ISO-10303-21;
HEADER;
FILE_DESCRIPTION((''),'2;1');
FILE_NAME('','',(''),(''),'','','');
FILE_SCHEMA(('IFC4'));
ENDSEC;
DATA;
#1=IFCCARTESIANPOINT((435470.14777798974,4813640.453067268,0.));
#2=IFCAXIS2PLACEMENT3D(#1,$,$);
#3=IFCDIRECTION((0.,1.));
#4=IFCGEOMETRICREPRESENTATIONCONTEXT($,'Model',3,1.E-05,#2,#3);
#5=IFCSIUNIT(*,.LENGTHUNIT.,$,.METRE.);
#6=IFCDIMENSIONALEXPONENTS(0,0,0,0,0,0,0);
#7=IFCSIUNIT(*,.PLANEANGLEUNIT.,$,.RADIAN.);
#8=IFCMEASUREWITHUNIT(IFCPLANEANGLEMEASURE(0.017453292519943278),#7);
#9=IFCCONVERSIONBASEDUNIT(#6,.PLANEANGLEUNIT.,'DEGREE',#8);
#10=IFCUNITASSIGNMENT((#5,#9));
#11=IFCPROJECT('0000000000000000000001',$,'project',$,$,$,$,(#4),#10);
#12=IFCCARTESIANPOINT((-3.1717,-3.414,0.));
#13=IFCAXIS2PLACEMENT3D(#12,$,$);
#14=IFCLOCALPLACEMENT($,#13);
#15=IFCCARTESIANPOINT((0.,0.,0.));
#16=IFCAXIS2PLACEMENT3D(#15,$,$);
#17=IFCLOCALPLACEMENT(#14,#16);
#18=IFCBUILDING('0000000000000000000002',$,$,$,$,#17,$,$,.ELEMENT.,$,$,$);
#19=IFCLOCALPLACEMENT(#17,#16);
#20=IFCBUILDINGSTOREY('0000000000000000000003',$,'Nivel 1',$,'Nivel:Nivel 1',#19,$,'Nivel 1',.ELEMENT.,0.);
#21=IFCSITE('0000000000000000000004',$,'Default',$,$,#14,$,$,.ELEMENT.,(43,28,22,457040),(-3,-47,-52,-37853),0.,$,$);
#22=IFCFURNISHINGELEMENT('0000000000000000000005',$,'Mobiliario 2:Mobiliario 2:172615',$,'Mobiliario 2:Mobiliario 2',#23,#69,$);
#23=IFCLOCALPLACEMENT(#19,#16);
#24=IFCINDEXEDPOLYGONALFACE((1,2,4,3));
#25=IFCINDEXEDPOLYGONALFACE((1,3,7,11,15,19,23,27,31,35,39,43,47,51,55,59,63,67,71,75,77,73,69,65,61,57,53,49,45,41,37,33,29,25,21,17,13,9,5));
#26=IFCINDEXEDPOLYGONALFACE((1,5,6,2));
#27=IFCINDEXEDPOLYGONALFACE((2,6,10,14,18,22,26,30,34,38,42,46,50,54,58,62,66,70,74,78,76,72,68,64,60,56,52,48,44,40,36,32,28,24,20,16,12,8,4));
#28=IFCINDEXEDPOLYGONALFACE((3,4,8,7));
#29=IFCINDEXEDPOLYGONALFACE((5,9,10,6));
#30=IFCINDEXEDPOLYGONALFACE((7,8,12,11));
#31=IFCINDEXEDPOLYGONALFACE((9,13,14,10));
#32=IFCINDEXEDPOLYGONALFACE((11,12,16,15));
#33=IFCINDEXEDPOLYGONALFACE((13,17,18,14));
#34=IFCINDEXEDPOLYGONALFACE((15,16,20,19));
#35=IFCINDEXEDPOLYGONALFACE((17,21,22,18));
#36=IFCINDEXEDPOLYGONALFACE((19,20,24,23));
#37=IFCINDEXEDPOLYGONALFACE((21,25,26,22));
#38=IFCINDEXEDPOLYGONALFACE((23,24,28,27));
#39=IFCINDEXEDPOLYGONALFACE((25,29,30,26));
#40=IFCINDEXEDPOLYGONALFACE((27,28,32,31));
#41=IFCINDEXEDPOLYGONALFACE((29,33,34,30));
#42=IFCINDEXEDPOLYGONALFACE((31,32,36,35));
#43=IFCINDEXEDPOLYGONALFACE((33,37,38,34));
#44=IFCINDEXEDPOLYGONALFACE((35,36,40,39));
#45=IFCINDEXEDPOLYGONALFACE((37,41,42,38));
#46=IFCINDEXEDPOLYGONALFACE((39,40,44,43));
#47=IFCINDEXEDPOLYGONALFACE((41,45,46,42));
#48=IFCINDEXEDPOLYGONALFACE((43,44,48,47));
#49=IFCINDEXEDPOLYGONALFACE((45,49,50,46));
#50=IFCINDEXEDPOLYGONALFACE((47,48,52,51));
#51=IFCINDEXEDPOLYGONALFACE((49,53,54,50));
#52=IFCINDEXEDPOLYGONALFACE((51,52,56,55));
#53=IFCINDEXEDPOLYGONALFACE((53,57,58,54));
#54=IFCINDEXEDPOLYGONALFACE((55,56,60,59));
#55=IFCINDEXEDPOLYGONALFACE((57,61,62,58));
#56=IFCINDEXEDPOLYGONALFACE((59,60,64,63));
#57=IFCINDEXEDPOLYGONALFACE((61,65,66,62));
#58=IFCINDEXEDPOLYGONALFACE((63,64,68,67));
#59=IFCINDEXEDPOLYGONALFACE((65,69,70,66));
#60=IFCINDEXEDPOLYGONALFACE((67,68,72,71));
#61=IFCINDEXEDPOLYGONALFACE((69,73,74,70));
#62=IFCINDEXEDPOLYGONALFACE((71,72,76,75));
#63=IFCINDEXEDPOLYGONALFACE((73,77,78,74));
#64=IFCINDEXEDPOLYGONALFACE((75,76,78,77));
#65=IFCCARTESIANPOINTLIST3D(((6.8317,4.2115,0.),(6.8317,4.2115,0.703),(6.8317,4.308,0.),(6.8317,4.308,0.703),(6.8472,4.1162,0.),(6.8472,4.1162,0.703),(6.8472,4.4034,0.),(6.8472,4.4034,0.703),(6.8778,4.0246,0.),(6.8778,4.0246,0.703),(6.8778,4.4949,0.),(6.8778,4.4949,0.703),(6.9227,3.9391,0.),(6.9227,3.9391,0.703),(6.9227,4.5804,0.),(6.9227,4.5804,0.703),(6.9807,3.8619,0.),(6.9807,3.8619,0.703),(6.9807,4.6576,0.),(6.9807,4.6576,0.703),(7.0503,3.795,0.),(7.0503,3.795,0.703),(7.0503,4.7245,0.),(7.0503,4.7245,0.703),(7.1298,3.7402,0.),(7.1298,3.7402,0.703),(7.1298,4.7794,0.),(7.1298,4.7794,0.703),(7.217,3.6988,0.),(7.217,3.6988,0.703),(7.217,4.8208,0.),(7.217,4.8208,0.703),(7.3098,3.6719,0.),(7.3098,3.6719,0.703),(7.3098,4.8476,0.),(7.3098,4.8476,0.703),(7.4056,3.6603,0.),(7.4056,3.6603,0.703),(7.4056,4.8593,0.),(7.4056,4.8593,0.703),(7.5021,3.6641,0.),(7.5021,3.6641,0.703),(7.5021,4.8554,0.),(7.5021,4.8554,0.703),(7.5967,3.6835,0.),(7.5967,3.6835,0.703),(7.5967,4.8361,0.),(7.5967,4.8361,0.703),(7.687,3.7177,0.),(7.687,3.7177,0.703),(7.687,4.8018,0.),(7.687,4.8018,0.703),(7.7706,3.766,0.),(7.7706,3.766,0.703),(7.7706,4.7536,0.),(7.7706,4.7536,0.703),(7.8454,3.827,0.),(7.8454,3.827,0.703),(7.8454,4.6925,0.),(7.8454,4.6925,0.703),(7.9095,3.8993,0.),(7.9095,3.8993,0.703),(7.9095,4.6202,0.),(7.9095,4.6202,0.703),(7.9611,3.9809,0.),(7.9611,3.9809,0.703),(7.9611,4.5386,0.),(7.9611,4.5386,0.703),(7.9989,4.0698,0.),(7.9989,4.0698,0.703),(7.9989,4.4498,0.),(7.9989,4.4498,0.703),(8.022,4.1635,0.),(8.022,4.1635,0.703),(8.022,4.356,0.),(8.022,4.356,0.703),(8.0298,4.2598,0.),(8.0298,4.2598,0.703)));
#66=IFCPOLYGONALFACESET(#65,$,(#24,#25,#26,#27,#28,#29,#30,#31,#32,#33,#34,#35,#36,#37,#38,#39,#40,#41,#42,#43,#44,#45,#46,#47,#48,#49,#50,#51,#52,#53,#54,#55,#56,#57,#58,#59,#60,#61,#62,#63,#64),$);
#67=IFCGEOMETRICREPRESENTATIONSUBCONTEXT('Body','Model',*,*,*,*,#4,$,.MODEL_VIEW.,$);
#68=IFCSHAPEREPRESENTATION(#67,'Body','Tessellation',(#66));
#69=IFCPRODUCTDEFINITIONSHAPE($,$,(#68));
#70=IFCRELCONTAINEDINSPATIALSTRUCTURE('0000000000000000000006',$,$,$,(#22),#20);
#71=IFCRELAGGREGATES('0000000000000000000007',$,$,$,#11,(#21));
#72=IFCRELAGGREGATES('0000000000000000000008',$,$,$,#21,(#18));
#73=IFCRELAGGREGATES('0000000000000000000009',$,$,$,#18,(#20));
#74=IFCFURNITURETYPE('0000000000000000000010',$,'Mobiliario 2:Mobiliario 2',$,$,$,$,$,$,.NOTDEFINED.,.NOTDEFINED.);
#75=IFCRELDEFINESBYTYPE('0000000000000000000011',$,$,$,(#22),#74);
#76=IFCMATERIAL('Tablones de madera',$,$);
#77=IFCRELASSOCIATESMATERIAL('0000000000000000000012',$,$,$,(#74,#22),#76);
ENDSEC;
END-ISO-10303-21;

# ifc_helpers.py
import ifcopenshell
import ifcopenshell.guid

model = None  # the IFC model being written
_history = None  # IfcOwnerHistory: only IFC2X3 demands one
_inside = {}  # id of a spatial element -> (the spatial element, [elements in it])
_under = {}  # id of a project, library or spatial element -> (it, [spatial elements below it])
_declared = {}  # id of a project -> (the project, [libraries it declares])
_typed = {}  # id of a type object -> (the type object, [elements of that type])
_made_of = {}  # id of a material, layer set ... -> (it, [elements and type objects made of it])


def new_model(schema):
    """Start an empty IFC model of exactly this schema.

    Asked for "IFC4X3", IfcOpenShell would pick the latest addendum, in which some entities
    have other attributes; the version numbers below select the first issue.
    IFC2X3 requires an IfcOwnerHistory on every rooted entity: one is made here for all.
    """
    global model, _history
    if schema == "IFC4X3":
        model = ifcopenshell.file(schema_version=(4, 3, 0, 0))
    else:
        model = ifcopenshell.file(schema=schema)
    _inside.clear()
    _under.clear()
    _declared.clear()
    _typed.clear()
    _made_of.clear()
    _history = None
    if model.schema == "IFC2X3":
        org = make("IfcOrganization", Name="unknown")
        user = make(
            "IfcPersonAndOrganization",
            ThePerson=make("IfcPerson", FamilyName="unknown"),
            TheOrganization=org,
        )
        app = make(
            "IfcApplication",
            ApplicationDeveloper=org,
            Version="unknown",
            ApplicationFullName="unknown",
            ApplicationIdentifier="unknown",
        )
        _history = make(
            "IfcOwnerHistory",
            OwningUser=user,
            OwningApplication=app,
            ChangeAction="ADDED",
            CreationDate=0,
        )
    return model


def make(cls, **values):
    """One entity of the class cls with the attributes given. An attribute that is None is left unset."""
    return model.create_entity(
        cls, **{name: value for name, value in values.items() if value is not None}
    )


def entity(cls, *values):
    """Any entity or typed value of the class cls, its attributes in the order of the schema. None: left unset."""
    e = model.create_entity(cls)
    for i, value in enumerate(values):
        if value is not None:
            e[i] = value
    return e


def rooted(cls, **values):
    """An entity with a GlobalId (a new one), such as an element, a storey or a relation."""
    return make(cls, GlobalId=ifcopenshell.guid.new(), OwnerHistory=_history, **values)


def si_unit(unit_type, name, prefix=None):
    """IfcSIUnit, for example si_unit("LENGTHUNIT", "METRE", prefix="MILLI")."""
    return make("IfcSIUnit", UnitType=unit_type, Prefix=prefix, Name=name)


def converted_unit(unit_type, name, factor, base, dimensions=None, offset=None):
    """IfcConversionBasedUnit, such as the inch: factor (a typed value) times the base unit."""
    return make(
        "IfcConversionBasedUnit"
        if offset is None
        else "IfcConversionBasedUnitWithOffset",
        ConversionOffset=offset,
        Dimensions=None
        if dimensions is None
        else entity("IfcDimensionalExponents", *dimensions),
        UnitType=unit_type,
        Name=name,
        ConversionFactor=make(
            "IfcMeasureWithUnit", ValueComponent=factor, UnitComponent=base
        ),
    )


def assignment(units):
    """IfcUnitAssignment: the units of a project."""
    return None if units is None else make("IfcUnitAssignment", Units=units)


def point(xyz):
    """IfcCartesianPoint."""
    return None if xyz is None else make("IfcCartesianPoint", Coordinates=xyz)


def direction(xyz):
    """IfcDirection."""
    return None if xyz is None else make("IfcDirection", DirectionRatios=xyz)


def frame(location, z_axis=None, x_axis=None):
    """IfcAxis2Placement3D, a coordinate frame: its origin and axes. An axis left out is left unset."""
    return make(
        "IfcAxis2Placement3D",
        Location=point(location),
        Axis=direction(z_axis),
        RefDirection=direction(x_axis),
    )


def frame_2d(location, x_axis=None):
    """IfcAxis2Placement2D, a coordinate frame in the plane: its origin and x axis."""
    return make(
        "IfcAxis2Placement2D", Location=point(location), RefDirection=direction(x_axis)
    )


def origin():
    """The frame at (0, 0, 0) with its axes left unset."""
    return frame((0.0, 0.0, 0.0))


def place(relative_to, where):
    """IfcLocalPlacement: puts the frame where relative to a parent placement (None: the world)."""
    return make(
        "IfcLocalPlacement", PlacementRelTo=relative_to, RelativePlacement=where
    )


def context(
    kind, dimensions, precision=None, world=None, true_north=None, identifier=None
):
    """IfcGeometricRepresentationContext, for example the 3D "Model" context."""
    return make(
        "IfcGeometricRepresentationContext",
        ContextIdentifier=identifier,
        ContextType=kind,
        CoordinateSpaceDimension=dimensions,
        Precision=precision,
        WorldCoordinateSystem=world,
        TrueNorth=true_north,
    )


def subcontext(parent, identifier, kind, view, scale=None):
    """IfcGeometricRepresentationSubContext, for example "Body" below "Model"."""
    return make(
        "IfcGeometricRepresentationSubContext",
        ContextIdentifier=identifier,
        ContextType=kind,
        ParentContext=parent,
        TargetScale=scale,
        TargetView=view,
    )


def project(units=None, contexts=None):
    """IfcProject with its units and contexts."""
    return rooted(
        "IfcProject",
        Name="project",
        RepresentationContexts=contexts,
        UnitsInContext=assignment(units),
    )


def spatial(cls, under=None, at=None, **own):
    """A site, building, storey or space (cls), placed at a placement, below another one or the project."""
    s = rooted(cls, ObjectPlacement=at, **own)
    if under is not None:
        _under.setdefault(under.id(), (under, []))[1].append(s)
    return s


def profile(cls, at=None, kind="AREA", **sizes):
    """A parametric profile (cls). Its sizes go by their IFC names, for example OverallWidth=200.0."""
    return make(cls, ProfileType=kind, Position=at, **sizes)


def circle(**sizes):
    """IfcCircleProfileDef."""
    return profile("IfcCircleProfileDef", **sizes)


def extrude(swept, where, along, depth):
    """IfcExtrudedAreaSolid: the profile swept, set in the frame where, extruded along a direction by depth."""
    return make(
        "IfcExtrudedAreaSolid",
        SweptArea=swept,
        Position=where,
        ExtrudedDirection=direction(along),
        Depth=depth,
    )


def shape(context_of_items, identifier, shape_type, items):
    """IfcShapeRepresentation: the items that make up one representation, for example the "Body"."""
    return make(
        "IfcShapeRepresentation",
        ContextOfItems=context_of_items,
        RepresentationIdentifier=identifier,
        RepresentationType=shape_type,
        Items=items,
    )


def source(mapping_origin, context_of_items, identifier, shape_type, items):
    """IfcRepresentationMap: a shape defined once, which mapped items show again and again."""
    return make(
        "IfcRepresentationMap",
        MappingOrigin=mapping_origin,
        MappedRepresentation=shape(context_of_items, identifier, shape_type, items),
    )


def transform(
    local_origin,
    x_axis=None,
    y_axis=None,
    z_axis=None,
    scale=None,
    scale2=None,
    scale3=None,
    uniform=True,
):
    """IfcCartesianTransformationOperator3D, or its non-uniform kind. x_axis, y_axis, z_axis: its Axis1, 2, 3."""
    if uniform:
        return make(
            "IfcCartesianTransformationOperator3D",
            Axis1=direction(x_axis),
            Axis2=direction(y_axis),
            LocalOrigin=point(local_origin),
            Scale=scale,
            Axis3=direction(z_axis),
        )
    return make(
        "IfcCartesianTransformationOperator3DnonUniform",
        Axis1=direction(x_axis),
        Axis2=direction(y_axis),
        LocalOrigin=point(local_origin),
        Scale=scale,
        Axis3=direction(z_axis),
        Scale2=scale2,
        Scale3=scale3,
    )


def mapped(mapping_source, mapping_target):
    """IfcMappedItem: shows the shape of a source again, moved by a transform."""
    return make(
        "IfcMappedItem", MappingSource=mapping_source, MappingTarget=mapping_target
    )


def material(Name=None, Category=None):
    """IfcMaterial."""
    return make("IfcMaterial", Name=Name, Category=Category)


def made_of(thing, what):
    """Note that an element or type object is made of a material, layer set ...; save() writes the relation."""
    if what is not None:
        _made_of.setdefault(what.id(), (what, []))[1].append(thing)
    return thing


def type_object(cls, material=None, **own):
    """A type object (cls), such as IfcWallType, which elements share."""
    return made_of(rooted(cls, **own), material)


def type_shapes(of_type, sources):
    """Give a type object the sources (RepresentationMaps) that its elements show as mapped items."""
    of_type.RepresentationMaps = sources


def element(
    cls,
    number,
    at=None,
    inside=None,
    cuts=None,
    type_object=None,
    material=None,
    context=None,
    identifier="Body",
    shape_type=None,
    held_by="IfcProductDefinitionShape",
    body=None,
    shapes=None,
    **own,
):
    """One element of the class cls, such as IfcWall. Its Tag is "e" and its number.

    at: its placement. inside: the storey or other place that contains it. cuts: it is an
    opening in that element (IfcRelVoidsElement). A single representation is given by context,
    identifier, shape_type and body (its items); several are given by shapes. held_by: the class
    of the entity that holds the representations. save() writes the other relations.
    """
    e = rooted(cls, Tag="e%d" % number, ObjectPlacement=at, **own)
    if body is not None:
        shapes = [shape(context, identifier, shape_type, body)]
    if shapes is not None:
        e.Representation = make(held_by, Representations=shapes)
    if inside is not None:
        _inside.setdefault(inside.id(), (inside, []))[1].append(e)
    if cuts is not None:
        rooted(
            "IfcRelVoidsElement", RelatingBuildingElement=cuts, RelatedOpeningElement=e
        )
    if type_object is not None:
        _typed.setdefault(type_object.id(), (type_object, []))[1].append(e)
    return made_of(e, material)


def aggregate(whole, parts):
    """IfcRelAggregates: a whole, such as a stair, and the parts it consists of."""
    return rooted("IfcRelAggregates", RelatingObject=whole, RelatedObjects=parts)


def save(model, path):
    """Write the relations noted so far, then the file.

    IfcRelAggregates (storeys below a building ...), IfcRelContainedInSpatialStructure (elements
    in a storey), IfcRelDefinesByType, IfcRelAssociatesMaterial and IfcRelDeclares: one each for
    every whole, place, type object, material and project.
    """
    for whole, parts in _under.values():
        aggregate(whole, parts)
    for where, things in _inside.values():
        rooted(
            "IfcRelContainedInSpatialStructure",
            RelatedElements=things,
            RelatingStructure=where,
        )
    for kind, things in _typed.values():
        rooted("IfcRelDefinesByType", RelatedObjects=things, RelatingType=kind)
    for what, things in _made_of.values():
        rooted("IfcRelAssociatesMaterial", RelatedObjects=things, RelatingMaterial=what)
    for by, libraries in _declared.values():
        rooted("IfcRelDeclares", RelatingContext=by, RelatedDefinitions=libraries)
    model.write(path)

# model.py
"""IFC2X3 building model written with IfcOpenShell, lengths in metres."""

from ifc_helpers import new_model, entity, si_unit, converted_unit, direction, frame, frame_2d, origin, place, context, subcontext, project, spatial, circle, extrude, source, transform, mapped, material, type_object, type_shapes, element, save


model = new_model("IFC2X3")

# Units and contexts
model_context = context("Model", 3, precision=1e-05, world=frame((435470.14777798974, 4813640.453067268, 0.0)), true_north=direction((0.0, 1.0)))
body_context = subcontext(model_context, "Body", "Model", "MODEL_VIEW")
ifc_project = project(units=[si_unit("LENGTHUNIT", "METRE"), converted_unit("PLANEANGLEUNIT", "DEGREE", entity("IfcPlaneAngleMeasure", 0.017453292519943278), si_unit("PLANEANGLEUNIT", "RADIAN"), dimensions=[0, 0, 0, 0, 0, 0, 0])], contexts=[model_context])

# Site, building, storey
site_placement = place(None, frame((-3.1717, -3.414, 0.0)))
site = spatial("IfcSite", under=ifc_project, at=site_placement, Name="Default", CompositionType="ELEMENT", RefLatitude=(43, 28, 22, 457040), RefLongitude=(-3, -47, -52, -37853), RefElevation=0.0)
building_placement = place(site_placement, origin())
building = spatial("IfcBuilding", under=site, at=building_placement, CompositionType="ELEMENT")
storey_placement = place(building_placement, origin())
storey = spatial("IfcBuildingStorey", under=building, at=storey_placement, Name="Nivel 1", ObjectType="Nivel:Nivel 1", LongName="Nivel 1", CompositionType="ELEMENT", Elevation=0.0)

# Furnishing element
ifc_material_1 = material(Name="Tablones de madera")
furniture_type_1 = type_object("IfcFurnitureType", Name="Mobiliario 2:Mobiliario 2", AssemblyPlace="NOTDEFINED", material=ifc_material_1)
shared_shape_1 = source(origin(), body_context, "Body", "SweptSolid", [
    extrude(circle(Radius=0.6, at=frame_2d((0.0, 0.0), x_axis=(1.0, 0.0))), frame((7.4298, 4.2598, 0.0)), (0.0, 0.0, 1.0), 0.703),
])
type_shapes(furniture_type_1, [shared_shape_1])
furnishing_1_placement = place(storey_placement, origin())
element("IfcFurnishingElement", 1, at=furnishing_1_placement, inside=storey, type_object=furniture_type_1, material=ifc_material_1, Name="Mobiliario 2:Mobiliario 2:172615", ObjectType="Mobiliario 2:Mobiliario 2", context=body_context, shape_type="MappedRepresentation", body=[
    mapped(shared_shape_1, transform((0.0, 0.0, 0.0), scale=1.0)),
])

save(model, "model.ifc")
